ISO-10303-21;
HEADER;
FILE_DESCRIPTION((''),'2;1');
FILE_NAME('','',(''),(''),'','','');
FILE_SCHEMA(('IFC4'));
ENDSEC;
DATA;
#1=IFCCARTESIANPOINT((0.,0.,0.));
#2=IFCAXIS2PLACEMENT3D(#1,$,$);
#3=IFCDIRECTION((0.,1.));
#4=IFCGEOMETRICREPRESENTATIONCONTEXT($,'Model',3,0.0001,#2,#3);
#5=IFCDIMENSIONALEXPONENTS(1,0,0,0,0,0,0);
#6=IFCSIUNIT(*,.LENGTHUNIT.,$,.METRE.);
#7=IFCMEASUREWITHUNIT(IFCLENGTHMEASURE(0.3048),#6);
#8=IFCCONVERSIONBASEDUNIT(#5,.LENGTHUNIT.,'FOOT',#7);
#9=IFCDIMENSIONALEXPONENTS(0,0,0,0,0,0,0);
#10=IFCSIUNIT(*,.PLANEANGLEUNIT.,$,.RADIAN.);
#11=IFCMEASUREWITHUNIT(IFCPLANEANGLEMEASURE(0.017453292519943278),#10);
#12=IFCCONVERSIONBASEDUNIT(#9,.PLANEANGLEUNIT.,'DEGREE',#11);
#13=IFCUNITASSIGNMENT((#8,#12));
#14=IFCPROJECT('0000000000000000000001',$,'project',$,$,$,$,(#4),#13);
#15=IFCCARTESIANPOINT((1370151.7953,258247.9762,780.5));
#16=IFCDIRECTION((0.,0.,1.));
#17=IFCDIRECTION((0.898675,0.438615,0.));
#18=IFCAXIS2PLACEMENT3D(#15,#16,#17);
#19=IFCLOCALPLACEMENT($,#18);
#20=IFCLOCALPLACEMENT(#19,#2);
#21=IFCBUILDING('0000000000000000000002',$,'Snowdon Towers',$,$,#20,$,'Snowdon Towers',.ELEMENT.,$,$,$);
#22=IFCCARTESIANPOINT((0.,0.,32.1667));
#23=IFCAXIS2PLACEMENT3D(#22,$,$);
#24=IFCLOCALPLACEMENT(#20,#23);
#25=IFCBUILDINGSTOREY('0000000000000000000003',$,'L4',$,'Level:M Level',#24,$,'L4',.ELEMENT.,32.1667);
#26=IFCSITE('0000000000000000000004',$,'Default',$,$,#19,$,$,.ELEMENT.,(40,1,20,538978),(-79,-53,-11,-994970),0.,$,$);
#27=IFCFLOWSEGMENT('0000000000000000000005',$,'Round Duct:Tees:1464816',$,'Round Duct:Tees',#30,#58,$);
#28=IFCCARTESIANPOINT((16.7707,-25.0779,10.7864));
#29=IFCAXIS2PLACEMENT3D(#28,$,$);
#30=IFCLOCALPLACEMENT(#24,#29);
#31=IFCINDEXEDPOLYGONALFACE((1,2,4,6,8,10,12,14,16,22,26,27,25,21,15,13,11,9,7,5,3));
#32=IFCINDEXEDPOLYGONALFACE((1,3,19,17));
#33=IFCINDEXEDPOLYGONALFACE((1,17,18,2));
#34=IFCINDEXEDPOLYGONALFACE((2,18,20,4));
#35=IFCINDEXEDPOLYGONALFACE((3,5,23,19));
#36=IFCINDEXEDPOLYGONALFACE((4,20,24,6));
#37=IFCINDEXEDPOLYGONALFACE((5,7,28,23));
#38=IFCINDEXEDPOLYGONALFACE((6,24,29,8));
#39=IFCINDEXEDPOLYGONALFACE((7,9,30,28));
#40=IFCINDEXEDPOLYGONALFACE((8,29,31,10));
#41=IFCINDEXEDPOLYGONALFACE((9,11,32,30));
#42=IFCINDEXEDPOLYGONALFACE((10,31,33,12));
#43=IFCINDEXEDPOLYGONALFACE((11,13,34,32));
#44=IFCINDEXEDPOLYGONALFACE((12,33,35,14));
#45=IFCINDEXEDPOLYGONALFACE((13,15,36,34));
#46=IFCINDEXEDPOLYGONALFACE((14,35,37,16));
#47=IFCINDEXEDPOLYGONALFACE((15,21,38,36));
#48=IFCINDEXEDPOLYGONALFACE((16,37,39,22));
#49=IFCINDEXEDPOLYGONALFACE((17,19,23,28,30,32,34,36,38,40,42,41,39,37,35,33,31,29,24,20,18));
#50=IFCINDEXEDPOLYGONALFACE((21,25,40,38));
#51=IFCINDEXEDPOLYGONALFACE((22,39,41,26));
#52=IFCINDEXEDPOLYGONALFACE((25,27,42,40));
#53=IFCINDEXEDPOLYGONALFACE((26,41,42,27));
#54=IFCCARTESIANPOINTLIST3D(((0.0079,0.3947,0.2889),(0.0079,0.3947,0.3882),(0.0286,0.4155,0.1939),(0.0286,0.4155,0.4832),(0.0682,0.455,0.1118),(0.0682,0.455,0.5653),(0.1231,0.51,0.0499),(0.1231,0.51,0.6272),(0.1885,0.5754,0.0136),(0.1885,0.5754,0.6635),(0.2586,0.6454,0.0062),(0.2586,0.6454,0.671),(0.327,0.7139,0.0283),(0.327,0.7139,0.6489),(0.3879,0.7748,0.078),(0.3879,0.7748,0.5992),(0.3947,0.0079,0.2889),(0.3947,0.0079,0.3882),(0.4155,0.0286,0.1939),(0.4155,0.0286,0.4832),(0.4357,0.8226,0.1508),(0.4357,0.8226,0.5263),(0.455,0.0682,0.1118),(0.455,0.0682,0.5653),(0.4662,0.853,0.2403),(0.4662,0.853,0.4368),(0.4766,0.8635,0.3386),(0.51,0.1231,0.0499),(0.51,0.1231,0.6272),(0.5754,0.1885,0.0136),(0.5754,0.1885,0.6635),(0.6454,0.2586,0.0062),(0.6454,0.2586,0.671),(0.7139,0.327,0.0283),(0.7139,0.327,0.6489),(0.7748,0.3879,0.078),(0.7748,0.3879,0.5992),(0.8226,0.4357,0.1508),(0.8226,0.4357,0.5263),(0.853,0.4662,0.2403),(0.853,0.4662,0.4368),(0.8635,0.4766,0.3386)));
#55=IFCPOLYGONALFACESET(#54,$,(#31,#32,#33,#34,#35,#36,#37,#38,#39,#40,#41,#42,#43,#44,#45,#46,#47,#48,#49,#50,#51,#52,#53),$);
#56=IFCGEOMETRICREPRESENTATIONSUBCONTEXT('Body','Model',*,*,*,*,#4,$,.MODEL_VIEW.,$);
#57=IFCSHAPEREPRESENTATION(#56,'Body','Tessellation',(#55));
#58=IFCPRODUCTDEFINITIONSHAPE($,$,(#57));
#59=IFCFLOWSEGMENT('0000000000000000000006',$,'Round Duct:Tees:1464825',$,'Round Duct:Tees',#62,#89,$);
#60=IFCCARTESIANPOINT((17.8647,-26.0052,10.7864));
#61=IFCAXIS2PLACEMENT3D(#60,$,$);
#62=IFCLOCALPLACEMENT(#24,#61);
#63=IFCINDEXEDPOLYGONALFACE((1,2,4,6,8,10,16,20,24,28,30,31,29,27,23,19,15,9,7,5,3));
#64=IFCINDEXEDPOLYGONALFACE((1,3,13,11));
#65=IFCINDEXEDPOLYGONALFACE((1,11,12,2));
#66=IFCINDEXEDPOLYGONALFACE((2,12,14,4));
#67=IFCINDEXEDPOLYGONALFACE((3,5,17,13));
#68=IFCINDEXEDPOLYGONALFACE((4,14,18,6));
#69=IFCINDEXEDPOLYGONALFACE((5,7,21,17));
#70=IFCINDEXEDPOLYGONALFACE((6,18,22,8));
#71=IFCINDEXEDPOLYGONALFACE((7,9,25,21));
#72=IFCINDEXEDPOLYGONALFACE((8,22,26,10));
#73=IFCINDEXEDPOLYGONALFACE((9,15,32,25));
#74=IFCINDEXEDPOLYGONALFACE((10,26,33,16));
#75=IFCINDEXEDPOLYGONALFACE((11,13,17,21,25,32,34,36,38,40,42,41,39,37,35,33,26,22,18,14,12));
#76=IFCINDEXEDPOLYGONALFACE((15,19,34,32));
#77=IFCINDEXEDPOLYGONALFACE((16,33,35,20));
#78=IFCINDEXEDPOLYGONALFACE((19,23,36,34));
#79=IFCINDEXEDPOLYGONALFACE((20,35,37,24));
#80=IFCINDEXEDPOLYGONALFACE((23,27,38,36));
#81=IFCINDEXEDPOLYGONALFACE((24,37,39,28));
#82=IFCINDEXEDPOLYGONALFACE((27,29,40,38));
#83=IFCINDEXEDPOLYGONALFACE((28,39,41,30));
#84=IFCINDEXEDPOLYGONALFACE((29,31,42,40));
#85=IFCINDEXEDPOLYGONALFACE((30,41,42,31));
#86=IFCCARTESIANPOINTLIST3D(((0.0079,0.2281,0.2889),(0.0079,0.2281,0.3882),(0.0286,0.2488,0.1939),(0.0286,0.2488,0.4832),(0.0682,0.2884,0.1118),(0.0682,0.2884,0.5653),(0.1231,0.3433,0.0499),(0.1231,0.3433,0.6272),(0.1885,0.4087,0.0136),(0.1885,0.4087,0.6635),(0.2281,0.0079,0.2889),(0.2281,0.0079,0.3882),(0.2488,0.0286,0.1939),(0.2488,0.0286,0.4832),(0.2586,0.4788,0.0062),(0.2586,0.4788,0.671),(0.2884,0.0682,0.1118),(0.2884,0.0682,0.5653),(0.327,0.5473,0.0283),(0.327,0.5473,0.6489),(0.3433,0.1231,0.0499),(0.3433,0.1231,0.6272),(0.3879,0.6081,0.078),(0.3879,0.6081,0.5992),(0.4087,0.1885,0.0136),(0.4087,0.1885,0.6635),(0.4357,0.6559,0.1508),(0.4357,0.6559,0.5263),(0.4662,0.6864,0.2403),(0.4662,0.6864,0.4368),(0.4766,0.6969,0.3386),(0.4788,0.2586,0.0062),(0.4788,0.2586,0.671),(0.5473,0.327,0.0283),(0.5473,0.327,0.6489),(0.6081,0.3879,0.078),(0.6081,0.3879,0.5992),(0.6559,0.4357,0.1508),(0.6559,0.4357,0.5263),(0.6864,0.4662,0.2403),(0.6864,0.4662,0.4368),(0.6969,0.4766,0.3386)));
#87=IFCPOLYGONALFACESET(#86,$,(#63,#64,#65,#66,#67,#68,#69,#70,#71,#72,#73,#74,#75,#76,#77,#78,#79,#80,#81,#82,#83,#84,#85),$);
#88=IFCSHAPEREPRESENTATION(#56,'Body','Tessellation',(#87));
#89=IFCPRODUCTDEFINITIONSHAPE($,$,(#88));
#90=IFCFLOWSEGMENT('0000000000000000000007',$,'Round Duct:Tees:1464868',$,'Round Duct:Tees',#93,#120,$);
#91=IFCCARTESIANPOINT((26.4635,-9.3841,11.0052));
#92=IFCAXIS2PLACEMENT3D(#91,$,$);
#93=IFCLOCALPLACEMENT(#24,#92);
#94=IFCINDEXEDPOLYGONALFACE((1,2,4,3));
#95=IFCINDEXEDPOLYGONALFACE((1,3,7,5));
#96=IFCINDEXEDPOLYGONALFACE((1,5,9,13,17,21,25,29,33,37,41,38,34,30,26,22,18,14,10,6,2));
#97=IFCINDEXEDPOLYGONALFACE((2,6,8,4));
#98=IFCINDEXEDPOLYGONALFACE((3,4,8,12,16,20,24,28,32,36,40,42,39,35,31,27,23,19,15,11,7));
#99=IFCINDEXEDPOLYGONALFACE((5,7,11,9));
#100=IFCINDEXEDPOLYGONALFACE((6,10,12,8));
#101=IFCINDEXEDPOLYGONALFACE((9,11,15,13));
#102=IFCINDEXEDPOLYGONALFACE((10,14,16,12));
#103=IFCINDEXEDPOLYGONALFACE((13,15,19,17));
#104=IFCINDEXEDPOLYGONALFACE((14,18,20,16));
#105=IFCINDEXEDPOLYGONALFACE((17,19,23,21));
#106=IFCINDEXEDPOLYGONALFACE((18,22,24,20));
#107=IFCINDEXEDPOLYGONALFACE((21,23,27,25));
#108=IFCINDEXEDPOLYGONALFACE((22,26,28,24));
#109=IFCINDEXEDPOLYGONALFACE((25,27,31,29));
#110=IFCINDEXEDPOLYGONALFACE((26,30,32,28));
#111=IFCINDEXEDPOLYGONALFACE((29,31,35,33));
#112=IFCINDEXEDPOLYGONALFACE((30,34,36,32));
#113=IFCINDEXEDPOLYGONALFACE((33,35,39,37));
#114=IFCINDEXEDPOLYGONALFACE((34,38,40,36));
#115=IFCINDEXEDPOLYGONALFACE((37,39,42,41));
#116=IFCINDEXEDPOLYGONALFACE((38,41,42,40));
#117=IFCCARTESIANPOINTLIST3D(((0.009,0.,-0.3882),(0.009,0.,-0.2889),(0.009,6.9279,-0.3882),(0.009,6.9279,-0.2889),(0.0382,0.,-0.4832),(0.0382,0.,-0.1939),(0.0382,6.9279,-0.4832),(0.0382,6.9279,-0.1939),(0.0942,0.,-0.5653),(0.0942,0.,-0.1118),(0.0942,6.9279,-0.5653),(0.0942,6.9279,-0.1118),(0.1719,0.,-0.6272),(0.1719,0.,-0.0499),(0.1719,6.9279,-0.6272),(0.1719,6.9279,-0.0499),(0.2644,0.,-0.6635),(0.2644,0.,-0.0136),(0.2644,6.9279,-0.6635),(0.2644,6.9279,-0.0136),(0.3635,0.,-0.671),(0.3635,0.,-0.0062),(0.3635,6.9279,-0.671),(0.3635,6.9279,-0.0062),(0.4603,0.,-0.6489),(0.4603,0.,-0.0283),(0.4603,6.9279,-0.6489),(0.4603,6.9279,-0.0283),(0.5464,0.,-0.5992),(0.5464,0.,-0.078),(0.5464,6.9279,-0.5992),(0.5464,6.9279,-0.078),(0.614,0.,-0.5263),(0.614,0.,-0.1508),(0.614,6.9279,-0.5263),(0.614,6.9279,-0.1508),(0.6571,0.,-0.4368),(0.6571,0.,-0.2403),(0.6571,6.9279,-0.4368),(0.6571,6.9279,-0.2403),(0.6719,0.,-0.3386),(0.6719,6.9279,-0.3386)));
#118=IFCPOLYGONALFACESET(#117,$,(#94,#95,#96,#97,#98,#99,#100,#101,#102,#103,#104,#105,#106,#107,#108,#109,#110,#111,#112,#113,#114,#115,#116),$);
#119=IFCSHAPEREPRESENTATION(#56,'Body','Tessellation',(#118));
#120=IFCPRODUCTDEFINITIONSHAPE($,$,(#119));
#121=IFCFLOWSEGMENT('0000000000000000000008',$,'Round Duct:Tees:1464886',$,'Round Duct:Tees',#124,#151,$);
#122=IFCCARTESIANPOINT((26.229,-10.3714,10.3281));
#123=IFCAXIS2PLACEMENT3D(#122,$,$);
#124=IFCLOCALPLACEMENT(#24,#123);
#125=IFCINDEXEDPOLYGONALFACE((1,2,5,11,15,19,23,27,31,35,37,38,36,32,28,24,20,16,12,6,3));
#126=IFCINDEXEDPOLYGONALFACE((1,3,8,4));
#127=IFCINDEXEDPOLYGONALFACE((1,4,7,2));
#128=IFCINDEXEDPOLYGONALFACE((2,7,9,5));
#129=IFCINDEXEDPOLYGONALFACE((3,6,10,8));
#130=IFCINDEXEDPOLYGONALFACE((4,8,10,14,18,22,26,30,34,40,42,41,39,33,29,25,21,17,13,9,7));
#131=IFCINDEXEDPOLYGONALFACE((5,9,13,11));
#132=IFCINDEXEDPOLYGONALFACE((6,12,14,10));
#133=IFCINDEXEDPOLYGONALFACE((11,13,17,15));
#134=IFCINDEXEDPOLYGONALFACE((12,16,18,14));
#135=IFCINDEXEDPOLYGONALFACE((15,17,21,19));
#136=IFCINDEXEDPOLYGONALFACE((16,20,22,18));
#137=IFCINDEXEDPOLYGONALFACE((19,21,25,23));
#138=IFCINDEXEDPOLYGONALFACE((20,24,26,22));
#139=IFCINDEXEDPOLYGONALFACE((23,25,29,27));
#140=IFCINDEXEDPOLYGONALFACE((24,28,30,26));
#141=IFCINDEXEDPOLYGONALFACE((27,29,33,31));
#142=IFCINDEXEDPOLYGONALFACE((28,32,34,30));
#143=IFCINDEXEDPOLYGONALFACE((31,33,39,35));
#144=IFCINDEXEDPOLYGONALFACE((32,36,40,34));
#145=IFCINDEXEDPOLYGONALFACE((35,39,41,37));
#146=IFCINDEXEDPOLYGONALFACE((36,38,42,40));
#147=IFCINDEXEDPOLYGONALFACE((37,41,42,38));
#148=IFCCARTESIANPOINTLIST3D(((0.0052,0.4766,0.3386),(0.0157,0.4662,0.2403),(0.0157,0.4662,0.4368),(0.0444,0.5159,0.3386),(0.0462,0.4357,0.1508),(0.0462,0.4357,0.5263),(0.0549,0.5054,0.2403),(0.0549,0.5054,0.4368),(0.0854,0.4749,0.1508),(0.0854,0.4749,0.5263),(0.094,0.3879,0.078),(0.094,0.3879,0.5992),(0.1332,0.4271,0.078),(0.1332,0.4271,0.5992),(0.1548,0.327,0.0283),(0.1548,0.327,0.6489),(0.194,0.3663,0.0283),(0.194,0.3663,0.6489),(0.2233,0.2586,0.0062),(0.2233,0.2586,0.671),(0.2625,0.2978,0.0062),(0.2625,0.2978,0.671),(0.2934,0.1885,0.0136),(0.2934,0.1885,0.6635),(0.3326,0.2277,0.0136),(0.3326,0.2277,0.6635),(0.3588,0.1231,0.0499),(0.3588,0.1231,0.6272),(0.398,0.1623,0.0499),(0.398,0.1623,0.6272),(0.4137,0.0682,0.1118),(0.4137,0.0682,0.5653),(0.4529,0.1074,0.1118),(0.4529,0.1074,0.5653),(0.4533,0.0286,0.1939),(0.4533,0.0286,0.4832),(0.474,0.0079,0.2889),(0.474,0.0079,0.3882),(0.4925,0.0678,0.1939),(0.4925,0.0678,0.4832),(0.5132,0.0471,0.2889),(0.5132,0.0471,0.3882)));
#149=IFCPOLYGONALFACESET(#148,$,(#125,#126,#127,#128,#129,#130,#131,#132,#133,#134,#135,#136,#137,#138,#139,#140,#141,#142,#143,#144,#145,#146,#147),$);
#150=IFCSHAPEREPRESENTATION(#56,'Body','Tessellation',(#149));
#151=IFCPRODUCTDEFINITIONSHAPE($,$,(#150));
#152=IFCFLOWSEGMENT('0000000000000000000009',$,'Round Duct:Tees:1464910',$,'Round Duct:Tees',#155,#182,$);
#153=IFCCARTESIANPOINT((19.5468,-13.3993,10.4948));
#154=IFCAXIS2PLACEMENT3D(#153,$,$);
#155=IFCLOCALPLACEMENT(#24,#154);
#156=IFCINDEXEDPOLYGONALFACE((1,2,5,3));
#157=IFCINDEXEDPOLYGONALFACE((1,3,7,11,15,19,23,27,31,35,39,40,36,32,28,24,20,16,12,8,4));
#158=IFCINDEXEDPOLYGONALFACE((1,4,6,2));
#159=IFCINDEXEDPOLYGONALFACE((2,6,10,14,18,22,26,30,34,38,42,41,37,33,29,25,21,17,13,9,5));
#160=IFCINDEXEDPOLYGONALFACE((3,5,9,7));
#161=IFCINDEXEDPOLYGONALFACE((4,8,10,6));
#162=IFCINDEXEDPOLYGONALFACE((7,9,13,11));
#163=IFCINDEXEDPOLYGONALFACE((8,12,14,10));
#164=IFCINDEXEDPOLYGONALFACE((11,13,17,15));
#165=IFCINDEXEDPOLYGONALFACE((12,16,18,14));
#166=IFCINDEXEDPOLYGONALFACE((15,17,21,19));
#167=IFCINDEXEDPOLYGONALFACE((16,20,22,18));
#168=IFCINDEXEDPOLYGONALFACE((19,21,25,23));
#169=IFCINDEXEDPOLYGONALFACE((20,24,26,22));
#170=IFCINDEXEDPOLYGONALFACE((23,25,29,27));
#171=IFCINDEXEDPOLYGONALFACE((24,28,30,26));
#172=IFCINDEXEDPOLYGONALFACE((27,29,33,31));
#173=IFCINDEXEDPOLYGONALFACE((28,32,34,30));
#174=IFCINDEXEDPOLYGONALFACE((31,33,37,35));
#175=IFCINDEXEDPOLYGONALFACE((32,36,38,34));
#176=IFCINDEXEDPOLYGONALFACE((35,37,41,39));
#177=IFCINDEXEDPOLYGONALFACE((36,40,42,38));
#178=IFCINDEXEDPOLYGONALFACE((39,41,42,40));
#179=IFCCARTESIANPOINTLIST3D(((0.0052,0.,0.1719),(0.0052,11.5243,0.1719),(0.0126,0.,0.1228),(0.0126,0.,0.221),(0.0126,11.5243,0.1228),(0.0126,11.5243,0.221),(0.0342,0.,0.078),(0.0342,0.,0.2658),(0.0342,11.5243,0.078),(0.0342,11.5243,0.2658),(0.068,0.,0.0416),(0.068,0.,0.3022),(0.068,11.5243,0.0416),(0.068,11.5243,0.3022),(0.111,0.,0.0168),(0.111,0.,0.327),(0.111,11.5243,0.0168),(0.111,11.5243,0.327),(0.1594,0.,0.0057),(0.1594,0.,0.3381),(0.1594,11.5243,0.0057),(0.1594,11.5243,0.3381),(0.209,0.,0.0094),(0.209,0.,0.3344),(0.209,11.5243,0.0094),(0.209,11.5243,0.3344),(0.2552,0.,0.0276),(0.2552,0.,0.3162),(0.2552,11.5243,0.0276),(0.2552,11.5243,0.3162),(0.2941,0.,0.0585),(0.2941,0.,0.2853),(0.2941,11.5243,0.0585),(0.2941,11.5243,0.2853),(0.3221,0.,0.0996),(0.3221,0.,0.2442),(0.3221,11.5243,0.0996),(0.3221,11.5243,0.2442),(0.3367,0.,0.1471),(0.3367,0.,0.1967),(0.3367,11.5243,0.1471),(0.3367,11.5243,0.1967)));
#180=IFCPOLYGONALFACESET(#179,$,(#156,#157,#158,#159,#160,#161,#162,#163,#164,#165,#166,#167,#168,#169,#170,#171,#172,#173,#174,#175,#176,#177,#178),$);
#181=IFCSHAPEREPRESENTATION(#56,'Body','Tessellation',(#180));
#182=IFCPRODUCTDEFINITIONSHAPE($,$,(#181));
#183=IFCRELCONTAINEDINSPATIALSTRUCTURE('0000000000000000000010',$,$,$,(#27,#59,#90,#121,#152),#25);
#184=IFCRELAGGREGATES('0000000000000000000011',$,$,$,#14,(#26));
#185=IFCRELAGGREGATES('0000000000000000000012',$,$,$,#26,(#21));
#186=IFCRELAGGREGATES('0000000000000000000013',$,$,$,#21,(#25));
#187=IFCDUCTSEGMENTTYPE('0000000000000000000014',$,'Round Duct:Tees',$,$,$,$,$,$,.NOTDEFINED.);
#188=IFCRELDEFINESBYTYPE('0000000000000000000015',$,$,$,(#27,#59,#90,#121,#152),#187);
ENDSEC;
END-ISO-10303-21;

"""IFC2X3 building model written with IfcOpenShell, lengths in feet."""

from ifc_helpers import new_model, entity, si_unit, converted_unit, direction, frame, frame_2d, origin, origin_2d_with_axis, place, context, subcontext, project, spatial, circle, extrude, type_object, element, save


model = new_model("IFC2X3")

# Units and contexts
model_context = context("Model", 3, precision=0.0001, world=origin(), true_north=direction((0.0, 1.0)))
body_context = subcontext(model_context, "Body", "Model", "MODEL_VIEW")
ifc_project = project(units=[converted_unit("LENGTHUNIT", "FOOT", entity("IfcLengthMeasure", 0.3048), si_unit("LENGTHUNIT", "METRE"), dimensions=[1, 0, 0, 0, 0, 0, 0]), converted_unit("PLANEANGLEUNIT", "DEGREE", entity("IfcPlaneAngleMeasure", 0.017453292519943278), si_unit("PLANEANGLEUNIT", "RADIAN"), dimensions=[0, 0, 0, 0, 0, 0, 0])], contexts=[model_context])

# Site, building, storey
site_placement = place(None, frame((1370151.7953, 258247.9762, 780.5), z_axis=(0.0, 0.0, 1.0), x_axis=(0.898675, 0.438615, 0.0)))
site = spatial("IfcSite", under=ifc_project, at=site_placement, Name="Default", CompositionType="ELEMENT", RefLatitude=(40, 1, 20, 538978), RefLongitude=(-79, -53, -11, -994970), RefElevation=0.0)
building_placement = place(site_placement, origin())
building = spatial("IfcBuilding", under=site, at=building_placement, Name="Snowdon Towers", LongName="Snowdon Towers", CompositionType="ELEMENT")
storey_placement = place(building_placement, frame((0.0, 0.0, 32.1667)))
storey = spatial("IfcBuildingStorey", under=building, at=storey_placement, Name="L4", ObjectType="Level:M Level", LongName="L4", CompositionType="ELEMENT", Elevation=32.1667)

# Flow segments
duct_segment_type = type_object("IfcDuctSegmentType", Name="Round Duct:Tees", PredefinedType="NOTDEFINED")
flow_segment_1_placement = place(storey_placement, frame((16.7707, -25.0779, 10.7864)))
element("IfcFlowSegment", 1, at=flow_segment_1_placement, inside=storey, type_object=duct_segment_type, Name="Round Duct:Tees:1464816", ObjectType="Round Duct:Tees", context=body_context, shape_type="SweptSolid", body=[
    extrude(circle(Radius=0.3333, at=frame_2d((0.0, 0.0), x_axis=(1.0, 0.0))), frame((0.2409, 0.6278, 0.3386), z_axis=(0.707107, -0.707107, 0.0), x_axis=(0.707107, 0.707107, 0.0)), (0.0, 0.0, 1.0), 0.5471),
])
flow_segment_2_placement = place(storey_placement, frame((17.8647, -26.0052, 10.7864)))
element("IfcFlowSegment", 2, at=flow_segment_2_placement, inside=storey, type_object=duct_segment_type, Name="Round Duct:Tees:1464825", ObjectType="Round Duct:Tees", context=body_context, shape_type="SweptSolid", body=[
    extrude(circle(Radius=0.3333, at=frame_2d((0.0, 0.0), x_axis=(1.0, 0.0))), frame((0.4611, 0.2409, 0.3386), z_axis=(-0.707107, 0.707107, 0.0), x_axis=(0.707107, 0.707107, 0.0)), (0.0, 0.0, 1.0), 0.3114),
])
flow_segment_3_placement = place(storey_placement, frame((26.4635, -9.3841, 11.0052)))
element("IfcFlowSegment", 3, at=flow_segment_3_placement, inside=storey, type_object=duct_segment_type, Name="Round Duct:Tees:1464868", ObjectType="Round Duct:Tees", context=body_context, shape_type="SweptSolid", body=[
    extrude(circle(Radius=0.3333, at=origin_2d_with_axis()), frame((0.3386, 0.0, -0.3386), z_axis=(0.0, 1.0, 0.0), x_axis=(1.0, 0.0, 0.0)), (0.0, 0.0, 1.0), 6.9279),
])
flow_segment_4_placement = place(storey_placement, frame((26.229, -10.3714, 10.3281)))
element("IfcFlowSegment", 4, at=flow_segment_4_placement, inside=storey, type_object=duct_segment_type, Name="Round Duct:Tees:1464886", ObjectType="Round Duct:Tees", context=body_context, shape_type="SweptSolid", body=[
    extrude(circle(Radius=0.3333, at=frame_2d((0.0, 0.0), x_axis=(1.0, 0.0))), frame((0.2409, 0.2409, 0.3386), z_axis=(0.707107, 0.707107, 0.0), x_axis=(-0.707107, 0.707107, 0.0)), (0.0, 0.0, 1.0), 0.0555),
])
flow_segment_5_placement = place(storey_placement, frame((19.5468, -13.3993, 10.4948)))
element("IfcFlowSegment", 5, at=flow_segment_5_placement, inside=storey, type_object=duct_segment_type, Name="Round Duct:Tees:1464910", ObjectType="Round Duct:Tees", context=body_context, shape_type="SweptSolid", body=[
    extrude(circle(Radius=0.1667, at=frame_2d((0.0, 0.0), x_axis=(1.0, 0.0))), frame((0.1719, 0.0, 0.1719), z_axis=(0.0, 1.0, 0.0), x_axis=(-1.0, 0.0, 0.0)), (0.0, 0.0, 1.0), 11.5243),
])

save(model, "model.ifc")
